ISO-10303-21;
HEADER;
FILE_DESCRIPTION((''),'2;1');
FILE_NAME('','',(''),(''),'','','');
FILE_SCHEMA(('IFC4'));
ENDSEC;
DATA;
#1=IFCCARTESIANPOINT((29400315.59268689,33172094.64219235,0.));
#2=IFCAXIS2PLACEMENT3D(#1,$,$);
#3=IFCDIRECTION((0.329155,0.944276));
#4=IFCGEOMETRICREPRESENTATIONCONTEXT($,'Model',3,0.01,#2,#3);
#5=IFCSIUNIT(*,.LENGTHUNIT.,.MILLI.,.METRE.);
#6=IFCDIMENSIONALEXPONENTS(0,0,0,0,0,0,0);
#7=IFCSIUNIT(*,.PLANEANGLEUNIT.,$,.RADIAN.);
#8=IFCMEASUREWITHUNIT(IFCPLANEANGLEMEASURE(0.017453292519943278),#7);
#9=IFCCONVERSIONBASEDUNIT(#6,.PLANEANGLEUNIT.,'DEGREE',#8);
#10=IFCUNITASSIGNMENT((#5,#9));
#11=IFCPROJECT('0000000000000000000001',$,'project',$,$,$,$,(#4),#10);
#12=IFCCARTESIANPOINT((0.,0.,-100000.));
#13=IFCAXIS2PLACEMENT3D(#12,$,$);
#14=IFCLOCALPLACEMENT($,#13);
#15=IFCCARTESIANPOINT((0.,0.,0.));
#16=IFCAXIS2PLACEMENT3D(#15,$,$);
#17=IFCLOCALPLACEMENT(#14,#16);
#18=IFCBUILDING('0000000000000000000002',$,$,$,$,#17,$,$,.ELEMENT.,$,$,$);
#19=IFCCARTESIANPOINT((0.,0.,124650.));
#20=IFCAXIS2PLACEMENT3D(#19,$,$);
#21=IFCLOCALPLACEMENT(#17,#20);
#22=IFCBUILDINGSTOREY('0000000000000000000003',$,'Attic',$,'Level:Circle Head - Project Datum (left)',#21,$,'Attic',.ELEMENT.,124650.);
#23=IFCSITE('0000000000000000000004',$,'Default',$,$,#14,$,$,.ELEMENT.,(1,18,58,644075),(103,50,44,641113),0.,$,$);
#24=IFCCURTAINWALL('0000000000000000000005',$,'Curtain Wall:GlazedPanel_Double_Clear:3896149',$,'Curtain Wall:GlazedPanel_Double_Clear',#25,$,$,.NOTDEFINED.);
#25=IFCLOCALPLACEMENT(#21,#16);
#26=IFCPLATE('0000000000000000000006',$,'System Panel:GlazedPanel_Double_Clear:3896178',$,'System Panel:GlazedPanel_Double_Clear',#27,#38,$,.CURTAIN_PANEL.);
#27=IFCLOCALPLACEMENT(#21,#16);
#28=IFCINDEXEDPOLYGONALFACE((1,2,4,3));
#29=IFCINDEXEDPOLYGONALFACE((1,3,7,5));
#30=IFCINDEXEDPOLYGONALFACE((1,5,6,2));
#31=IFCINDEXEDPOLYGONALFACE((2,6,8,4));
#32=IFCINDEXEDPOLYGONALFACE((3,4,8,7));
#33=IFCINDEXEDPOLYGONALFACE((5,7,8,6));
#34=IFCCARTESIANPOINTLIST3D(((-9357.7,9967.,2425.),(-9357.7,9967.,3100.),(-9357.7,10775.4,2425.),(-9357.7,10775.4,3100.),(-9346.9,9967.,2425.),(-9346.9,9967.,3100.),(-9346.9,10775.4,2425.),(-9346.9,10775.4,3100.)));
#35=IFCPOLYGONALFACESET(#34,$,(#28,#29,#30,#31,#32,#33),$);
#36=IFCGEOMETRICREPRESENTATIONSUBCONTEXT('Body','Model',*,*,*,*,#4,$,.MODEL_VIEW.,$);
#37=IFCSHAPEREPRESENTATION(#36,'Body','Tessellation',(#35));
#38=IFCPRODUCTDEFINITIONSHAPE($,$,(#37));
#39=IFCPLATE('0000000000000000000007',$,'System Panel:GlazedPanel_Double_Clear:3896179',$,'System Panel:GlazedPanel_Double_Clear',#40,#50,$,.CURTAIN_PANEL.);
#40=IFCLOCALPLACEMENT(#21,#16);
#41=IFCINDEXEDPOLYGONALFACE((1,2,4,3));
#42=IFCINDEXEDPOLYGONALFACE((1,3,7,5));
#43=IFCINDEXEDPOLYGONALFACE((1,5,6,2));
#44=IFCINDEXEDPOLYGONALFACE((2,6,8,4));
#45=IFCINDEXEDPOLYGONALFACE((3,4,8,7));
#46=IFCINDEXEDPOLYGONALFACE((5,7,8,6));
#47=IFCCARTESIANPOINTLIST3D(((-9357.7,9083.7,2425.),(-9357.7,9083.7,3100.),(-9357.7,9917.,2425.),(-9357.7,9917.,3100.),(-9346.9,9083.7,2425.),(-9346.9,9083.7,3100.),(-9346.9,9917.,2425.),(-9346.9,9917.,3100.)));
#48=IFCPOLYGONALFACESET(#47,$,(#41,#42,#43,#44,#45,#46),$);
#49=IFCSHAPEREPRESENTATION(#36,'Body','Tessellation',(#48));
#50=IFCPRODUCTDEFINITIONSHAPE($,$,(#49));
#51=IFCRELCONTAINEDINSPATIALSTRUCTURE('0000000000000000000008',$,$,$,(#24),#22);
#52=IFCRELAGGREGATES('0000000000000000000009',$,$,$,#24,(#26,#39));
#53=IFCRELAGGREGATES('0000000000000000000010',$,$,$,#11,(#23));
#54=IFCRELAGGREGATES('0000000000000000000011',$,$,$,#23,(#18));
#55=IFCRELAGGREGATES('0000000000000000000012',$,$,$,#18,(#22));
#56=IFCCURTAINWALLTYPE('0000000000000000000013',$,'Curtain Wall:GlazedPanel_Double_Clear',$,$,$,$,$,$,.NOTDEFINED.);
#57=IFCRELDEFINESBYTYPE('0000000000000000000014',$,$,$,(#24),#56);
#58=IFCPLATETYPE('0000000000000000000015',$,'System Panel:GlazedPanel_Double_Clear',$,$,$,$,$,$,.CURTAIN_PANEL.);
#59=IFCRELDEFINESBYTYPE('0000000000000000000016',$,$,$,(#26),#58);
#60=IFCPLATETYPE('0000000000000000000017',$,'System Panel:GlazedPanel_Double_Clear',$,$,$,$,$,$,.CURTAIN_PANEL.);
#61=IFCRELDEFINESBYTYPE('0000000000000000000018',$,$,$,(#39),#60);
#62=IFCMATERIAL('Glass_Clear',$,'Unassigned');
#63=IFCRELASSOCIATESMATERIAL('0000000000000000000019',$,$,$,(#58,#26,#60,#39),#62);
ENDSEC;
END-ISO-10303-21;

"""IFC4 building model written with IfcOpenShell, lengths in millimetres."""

from ifc_helpers import new_model, entity, si_unit, converted_unit, direction, frame, origin, place, context, subcontext, project, spatial, indexed_curve, outline, extrude, source, transform, mapped, material, type_object, type_shapes, element, aggregate, save


model = new_model("IFC4")

# Units and contexts
model_context = context("Model", 3, precision=0.01, world=frame((29400315.59268689, 33172094.64219235, 0.0)), true_north=direction((0.329155, 0.944276)))
body_context = subcontext(model_context, "Body", "Model", "MODEL_VIEW")
ifc_project = project(units=[si_unit("LENGTHUNIT", "METRE", prefix="MILLI"), converted_unit("PLANEANGLEUNIT", "DEGREE", entity("IfcPlaneAngleMeasure", 0.017453292519943278), si_unit("PLANEANGLEUNIT", "RADIAN"), dimensions=[0, 0, 0, 0, 0, 0, 0])], contexts=[model_context])

# Site, building, storey
site_placement = place(None, frame((0.0, 0.0, -100000.0)))
site = spatial("IfcSite", under=ifc_project, at=site_placement, Name="Default", CompositionType="ELEMENT", RefLatitude=(1, 18, 58, 644075), RefLongitude=(103, 50, 44, 641113), RefElevation=0.0)
building_placement = place(site_placement, origin())
building = spatial("IfcBuilding", under=site, at=building_placement, CompositionType="ELEMENT")
storey_placement = place(building_placement, frame((0.0, 0.0, 124650.0)))
storey = spatial("IfcBuildingStorey", under=building, at=storey_placement, Name="Attic", ObjectType="Level:Circle Head - Project Datum (left)", LongName="Attic", CompositionType="ELEMENT", Elevation=124650.0)

# Curtain wall, plates
curtain_wall_type = type_object("IfcCurtainWallType", Name="Curtain Wall:GlazedPanel_Double_Clear", PredefinedType="NOTDEFINED")
curtain_wall_placement = place(storey_placement, frame((0.0, 0.0, -124650.0)))
curtain_wall = element("IfcCurtainWall", 1, at=curtain_wall_placement, inside=storey, type_object=curtain_wall_type, Name="Curtain Wall:GlazedPanel_Double_Clear:3896149", ObjectType="Curtain Wall:GlazedPanel_Double_Clear", PredefinedType="NOTDEFINED")
ifc_material_1 = material(Name="Glass_Clear", Category="Unassigned")
plate_type_1 = type_object("IfcPlateType", Name="System Panel:GlazedPanel_Double_Clear", PredefinedType="CURTAIN_PANEL", material=ifc_material_1)
shared_shape_1 = source(origin(), body_context, "Body", "SweptSolid", [
    extrude(outline(indexed_curve([(-5.4, -404.2), (5.4, -404.2), (5.4, 404.2), (-5.4, 404.2), (-5.4, -404.2)], self_intersect=False)), frame((0.0, 111.0, 0.0), z_axis=(0.0, 0.0, 1.0), x_axis=(0.0, 1.0, 0.0)), (0.0, 0.0, 1.0), 675.0),
])
type_shapes(plate_type_1, [shared_shape_1])
plate_1_placement = place(curtain_wall_placement, frame((-9463.3, 10371.2, 127075.0), z_axis=(0.0, 0.0, 1.0), x_axis=(0.0, -1.0, 0.0)))
plate_1 = element("IfcPlate", 2, at=plate_1_placement, type_object=plate_type_1, material=ifc_material_1, Name="System Panel:GlazedPanel_Double_Clear:3896178", ObjectType="System Panel:GlazedPanel_Double_Clear", PredefinedType="CURTAIN_PANEL", context=body_context, shape_type="MappedRepresentation", body=[
    mapped(shared_shape_1, transform((0.0, 0.0, 0.0), scale=1.0)),
])
plate_type_2 = type_object("IfcPlateType", Name="System Panel:GlazedPanel_Double_Clear", PredefinedType="CURTAIN_PANEL", material=ifc_material_1)
shared_shape_2 = source(origin(), body_context, "Body", "SweptSolid", [
    extrude(outline(indexed_curve([(-5.4, -416.7), (5.4, -416.7), (5.4, 416.7), (-5.4, 416.7), (-5.4, -416.7)], self_intersect=False)), frame((0.0, 111.0, 0.0), z_axis=(0.0, 0.0, 1.0), x_axis=(0.0, 1.0, 0.0)), (0.0, 0.0, 1.0), 675.0),
])
type_shapes(plate_type_2, [shared_shape_2])
plate_2_placement = place(curtain_wall_placement, frame((-9463.3, 9500.4, 127075.0), z_axis=(0.0, 0.0, 1.0), x_axis=(0.0, -1.0, 0.0)))
plate_2 = element("IfcPlate", 3, at=plate_2_placement, type_object=plate_type_2, material=ifc_material_1, Name="System Panel:GlazedPanel_Double_Clear:3896179", ObjectType="System Panel:GlazedPanel_Double_Clear", PredefinedType="CURTAIN_PANEL", context=body_context, shape_type="MappedRepresentation", body=[
    mapped(shared_shape_2, transform((0.0, 0.0, 0.0), scale=1.0)),
])
aggregate(curtain_wall, [plate_1, plate_2])

save(model, "model.ifc")
